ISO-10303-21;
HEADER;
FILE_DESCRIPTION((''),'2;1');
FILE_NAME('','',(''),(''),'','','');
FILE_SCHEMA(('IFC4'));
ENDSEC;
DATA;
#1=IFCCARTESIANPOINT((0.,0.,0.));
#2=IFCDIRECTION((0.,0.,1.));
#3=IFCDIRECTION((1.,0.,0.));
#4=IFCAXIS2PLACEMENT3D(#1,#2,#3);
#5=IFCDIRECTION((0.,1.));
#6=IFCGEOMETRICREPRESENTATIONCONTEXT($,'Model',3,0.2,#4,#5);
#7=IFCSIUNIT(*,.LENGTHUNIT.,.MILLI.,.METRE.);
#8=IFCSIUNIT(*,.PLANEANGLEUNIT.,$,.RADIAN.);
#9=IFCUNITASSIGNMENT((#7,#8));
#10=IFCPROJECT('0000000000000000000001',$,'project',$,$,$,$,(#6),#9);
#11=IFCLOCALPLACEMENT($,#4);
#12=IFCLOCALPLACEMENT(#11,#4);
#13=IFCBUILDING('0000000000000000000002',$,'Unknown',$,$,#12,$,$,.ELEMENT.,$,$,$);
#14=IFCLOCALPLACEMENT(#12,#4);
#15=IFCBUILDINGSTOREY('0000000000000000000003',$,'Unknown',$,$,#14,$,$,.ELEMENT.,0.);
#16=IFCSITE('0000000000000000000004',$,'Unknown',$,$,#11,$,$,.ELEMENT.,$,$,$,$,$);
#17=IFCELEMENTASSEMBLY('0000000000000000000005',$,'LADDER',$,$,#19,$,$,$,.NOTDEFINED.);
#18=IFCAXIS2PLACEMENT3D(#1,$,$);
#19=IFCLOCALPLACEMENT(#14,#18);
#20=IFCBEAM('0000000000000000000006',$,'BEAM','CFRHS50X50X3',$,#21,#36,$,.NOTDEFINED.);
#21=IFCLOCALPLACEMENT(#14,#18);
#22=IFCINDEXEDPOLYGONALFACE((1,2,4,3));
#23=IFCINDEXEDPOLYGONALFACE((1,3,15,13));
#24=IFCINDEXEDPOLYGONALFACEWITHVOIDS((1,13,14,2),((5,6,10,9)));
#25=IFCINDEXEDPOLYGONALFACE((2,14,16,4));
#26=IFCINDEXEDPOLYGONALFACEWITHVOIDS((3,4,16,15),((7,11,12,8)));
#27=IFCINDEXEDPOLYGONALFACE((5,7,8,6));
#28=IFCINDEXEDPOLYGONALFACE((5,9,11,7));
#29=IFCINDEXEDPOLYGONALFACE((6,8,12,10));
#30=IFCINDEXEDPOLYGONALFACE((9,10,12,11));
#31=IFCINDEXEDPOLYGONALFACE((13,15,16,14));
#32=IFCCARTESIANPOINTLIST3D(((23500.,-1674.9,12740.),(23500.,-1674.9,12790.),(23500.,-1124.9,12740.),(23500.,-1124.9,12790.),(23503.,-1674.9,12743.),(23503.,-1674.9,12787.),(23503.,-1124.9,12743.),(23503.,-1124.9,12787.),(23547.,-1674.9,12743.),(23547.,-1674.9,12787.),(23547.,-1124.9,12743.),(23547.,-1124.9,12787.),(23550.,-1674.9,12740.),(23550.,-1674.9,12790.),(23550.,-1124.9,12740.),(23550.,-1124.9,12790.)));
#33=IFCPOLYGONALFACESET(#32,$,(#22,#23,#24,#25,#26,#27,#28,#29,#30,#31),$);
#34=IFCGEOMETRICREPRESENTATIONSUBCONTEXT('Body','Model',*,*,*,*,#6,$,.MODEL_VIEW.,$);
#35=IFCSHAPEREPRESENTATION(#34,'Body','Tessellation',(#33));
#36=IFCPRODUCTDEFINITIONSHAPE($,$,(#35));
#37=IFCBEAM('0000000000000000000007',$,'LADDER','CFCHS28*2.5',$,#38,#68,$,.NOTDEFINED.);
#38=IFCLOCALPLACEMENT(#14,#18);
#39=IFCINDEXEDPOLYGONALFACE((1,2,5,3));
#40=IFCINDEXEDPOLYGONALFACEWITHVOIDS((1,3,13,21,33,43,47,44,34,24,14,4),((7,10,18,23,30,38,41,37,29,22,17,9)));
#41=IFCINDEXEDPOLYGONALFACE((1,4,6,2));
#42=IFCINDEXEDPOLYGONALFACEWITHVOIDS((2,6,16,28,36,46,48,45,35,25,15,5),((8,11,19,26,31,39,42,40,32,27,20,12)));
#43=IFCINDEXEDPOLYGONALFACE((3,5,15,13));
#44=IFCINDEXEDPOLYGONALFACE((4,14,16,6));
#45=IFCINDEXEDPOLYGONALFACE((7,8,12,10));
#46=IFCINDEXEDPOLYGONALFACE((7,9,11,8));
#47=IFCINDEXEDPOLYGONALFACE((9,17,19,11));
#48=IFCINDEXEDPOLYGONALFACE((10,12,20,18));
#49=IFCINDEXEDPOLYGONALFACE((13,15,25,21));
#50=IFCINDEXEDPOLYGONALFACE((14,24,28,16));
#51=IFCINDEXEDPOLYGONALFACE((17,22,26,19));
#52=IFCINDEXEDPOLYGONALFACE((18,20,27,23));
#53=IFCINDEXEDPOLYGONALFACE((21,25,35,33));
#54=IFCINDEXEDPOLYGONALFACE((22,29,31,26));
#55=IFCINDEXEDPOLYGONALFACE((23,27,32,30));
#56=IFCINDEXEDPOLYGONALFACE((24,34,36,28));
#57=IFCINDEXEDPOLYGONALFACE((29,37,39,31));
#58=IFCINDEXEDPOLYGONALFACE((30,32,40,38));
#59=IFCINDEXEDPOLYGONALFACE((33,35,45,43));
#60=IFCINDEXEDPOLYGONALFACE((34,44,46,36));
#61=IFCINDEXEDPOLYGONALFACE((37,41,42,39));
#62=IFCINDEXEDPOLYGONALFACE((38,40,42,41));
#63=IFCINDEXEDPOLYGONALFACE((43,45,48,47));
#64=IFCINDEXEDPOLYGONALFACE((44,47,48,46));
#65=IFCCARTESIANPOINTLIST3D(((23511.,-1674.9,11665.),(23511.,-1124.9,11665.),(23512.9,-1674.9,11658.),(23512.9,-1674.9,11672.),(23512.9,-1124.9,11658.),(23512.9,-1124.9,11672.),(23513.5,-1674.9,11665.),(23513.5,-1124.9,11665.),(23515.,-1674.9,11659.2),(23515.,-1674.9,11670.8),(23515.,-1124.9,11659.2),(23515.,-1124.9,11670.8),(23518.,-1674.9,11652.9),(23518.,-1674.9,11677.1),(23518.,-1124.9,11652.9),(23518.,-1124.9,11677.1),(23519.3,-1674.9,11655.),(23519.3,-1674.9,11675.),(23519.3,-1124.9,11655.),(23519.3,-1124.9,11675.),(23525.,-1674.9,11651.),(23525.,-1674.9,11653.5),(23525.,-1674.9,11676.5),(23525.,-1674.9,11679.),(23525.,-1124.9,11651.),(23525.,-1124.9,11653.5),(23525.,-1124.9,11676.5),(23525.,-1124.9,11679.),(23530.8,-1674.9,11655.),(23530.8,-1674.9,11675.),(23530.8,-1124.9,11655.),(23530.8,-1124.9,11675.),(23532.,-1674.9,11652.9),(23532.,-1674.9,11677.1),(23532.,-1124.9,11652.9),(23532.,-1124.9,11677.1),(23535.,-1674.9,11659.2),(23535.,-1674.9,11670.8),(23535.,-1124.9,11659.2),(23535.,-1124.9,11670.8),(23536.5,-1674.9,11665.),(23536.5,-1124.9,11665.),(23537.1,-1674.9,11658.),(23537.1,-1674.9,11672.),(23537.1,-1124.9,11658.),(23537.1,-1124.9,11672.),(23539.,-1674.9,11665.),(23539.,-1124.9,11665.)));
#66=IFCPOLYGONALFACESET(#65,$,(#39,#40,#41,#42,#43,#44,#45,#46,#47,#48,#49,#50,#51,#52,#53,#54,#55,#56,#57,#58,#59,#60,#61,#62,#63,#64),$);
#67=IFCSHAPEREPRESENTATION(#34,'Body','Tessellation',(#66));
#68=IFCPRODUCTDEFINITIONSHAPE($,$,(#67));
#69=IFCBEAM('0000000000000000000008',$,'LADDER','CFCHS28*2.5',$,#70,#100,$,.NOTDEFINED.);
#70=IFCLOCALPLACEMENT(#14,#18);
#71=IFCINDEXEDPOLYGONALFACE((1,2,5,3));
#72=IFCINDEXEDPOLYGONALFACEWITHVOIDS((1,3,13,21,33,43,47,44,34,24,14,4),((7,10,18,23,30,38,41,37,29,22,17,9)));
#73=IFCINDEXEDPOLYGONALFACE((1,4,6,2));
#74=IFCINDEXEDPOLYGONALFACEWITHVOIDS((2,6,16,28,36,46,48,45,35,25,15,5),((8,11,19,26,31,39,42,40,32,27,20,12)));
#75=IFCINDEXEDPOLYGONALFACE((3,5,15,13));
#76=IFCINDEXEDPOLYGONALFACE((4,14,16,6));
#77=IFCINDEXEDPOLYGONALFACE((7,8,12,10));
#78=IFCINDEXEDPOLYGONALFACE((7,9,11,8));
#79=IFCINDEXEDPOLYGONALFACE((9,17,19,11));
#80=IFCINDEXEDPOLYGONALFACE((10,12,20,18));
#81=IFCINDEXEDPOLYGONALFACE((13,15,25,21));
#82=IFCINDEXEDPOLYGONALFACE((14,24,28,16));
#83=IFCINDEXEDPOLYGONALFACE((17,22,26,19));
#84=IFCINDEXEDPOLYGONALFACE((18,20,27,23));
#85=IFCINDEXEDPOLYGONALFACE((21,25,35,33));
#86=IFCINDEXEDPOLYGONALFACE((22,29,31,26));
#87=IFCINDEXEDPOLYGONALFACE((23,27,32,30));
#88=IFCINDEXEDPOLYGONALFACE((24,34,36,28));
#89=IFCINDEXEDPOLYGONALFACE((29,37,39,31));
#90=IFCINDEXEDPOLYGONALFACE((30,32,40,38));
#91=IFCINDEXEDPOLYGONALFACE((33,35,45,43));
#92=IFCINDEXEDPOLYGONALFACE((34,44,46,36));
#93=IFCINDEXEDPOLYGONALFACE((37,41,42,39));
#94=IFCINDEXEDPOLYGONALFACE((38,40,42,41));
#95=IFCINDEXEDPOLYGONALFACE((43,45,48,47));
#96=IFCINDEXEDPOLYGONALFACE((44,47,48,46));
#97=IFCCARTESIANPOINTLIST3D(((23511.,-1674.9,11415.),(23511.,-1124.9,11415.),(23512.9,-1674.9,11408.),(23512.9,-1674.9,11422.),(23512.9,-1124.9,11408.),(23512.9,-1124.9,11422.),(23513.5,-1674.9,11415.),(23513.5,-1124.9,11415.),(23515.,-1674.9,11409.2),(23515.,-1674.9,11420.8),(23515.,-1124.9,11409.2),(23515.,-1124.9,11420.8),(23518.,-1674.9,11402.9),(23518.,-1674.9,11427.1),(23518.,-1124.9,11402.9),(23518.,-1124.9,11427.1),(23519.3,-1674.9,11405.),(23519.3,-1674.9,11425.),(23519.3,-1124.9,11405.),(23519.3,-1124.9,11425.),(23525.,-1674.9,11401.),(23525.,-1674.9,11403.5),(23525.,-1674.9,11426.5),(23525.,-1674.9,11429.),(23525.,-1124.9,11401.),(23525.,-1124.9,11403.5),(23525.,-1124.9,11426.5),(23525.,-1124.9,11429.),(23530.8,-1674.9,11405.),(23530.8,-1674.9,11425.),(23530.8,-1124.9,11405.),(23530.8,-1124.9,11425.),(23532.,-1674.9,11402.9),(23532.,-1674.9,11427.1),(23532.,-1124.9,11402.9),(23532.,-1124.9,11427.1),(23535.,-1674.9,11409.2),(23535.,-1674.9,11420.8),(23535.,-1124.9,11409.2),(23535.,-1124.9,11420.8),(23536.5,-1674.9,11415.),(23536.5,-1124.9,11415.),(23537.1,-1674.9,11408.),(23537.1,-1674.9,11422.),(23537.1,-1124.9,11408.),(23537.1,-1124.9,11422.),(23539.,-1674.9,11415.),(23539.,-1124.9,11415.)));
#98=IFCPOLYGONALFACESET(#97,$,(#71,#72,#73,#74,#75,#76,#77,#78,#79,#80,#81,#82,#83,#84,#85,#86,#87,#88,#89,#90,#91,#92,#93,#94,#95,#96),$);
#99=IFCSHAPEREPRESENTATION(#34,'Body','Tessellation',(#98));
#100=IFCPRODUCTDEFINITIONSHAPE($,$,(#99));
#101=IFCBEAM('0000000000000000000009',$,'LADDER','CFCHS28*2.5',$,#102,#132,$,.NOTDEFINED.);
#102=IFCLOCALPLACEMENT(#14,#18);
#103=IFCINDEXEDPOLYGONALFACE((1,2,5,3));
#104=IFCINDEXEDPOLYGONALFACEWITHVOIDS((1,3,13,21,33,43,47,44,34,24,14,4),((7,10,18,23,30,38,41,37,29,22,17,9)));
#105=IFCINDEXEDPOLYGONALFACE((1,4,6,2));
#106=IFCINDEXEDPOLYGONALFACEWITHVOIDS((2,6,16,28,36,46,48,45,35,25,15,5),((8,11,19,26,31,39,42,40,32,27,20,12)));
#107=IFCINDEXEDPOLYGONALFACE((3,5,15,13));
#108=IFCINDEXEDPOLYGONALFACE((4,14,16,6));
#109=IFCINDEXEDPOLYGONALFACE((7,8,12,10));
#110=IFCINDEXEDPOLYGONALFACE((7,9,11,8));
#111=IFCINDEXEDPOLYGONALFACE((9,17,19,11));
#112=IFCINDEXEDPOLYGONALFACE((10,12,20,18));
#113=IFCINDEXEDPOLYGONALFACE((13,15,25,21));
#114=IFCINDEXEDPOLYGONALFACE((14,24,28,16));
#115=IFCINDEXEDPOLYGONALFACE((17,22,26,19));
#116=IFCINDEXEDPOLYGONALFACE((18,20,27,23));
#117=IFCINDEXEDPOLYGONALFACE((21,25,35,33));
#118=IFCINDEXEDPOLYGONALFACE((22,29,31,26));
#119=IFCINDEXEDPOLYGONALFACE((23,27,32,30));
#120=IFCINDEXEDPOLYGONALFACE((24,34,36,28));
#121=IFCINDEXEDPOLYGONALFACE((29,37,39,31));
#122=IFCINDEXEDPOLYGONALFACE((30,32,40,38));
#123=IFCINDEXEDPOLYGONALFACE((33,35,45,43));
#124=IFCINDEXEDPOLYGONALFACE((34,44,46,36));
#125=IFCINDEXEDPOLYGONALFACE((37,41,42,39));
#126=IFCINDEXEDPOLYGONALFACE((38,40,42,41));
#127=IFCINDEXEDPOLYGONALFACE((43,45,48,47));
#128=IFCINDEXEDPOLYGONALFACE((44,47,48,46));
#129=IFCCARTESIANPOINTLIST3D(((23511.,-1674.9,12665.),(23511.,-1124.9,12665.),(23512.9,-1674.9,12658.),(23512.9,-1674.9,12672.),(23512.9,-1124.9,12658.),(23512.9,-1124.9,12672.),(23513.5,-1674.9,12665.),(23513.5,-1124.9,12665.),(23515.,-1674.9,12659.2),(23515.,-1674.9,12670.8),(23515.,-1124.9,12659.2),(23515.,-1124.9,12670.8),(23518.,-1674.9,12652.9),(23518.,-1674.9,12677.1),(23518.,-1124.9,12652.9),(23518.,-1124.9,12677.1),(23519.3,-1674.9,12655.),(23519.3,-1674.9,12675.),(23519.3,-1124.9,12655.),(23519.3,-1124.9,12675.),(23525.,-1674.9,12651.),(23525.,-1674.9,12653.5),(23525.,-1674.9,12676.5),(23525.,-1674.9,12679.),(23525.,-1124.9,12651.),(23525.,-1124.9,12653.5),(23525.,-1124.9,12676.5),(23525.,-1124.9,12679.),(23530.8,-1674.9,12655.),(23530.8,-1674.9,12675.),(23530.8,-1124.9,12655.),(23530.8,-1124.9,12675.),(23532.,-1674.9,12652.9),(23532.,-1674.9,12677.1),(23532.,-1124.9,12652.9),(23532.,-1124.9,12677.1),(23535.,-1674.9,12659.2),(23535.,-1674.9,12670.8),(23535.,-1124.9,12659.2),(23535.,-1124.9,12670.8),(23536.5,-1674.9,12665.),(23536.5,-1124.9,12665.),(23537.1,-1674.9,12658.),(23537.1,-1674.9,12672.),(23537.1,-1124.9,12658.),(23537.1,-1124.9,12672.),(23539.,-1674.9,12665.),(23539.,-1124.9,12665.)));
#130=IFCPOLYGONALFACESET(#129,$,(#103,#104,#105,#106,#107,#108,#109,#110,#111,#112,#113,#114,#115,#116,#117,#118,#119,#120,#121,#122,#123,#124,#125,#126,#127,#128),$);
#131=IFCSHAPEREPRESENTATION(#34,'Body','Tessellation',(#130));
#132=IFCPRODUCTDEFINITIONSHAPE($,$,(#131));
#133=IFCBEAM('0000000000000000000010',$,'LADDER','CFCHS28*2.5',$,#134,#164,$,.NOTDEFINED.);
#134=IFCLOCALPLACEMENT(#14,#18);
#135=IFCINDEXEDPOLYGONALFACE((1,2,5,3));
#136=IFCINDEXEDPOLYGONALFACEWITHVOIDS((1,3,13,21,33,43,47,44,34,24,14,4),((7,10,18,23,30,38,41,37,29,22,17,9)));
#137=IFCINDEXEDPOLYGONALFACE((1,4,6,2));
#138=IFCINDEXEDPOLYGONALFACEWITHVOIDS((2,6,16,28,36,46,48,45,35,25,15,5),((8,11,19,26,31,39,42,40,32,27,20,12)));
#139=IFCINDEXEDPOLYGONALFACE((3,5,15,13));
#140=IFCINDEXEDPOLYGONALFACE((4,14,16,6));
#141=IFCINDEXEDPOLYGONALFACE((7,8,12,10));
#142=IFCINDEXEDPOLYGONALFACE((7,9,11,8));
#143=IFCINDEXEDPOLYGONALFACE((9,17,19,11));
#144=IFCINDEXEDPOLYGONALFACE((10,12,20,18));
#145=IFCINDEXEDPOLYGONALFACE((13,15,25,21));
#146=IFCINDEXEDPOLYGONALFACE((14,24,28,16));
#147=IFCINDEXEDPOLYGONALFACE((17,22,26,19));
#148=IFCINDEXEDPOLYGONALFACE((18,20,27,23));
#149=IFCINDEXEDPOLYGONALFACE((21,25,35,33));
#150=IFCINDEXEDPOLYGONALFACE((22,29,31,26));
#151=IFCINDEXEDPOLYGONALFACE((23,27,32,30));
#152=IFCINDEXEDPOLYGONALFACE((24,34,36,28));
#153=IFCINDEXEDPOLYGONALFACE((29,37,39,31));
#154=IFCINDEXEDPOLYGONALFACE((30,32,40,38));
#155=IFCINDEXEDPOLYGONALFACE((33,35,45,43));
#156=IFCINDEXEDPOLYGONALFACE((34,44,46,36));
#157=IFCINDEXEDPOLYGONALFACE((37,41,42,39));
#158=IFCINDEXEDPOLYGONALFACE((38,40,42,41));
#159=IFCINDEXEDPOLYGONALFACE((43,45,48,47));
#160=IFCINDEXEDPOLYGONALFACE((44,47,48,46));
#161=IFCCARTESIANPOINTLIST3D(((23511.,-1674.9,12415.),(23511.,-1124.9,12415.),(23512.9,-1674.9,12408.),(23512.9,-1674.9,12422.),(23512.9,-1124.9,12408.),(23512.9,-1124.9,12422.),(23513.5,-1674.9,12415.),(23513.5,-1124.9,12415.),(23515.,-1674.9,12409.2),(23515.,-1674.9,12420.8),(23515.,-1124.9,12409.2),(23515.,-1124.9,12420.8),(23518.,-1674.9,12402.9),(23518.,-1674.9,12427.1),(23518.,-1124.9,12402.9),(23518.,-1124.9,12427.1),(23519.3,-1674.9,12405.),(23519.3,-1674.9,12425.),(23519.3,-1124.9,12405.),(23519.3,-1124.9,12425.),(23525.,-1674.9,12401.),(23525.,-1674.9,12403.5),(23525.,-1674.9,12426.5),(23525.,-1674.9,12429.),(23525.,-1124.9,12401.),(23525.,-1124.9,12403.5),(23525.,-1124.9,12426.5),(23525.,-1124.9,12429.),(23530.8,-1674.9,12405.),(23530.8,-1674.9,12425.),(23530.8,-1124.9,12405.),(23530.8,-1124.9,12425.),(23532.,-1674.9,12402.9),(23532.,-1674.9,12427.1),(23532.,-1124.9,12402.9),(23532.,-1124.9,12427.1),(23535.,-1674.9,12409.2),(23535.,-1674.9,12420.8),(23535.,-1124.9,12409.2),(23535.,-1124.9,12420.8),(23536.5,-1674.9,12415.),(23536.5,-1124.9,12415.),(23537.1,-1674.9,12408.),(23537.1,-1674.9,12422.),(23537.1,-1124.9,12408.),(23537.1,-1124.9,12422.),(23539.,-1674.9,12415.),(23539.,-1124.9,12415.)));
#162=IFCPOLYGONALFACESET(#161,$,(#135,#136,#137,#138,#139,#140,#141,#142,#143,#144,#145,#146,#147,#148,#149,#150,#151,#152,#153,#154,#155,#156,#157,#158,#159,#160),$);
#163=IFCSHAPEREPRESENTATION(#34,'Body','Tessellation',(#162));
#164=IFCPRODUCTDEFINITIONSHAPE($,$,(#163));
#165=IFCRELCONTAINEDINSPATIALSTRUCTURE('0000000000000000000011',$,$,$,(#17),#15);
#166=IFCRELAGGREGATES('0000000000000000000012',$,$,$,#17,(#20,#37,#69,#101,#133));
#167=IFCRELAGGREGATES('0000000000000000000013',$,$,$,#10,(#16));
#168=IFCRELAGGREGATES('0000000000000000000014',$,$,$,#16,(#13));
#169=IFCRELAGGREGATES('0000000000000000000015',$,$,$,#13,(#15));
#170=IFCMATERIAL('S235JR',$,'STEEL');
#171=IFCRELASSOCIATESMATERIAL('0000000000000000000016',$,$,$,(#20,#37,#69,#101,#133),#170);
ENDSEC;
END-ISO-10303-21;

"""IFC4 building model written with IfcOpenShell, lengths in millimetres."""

from ifc_helpers import new_model, si_unit, direction, frame, origin_with_axes, place, context, subcontext, project, spatial, line, indexed_curve, outline, extrude, material, element, aggregate, save


model = new_model("IFC4")

# Units and contexts
model_context = context("Model", 3, precision=0.2, world=origin_with_axes(), true_north=direction((0.0, 1.0)))
body_context = subcontext(model_context, "Body", "Model", "MODEL_VIEW")
ifc_project = project(units=[si_unit("LENGTHUNIT", "METRE", prefix="MILLI"), si_unit("PLANEANGLEUNIT", "RADIAN")], contexts=[model_context])

# Site, building, storey
site_placement = place(None, origin_with_axes())
site = spatial("IfcSite", under=ifc_project, at=site_placement, Name="Unknown", CompositionType="ELEMENT")
building_placement = place(site_placement, origin_with_axes())
building = spatial("IfcBuilding", under=site, at=building_placement, Name="Unknown", CompositionType="ELEMENT")
storey_placement = place(building_placement, origin_with_axes())
storey = spatial("IfcBuildingStorey", under=building, at=storey_placement, Name="Unknown", CompositionType="ELEMENT", Elevation=0.0)

# Element assembly, beams
assembly_1_placement = place(storey_placement, frame((23525.0, -1699.9, 5175.0), z_axis=(0.0, 1.0, 0.0), x_axis=(0.0, 0.0, 1.0)))
assembly_1 = element("IfcElementAssembly", 1, at=assembly_1_placement, inside=storey, Name="LADDER", PredefinedType="NOTDEFINED")
ifc_material_1 = material(Name="S235JR", Category="STEEL")
beam_1_placement = place(assembly_1_placement, frame((7590.0, 0.0, 25.0), z_axis=(0.0, 1.0, 0.0), x_axis=(0.0, 0.0, 1.0)))
beam_1 = element("IfcBeam", 2, at=beam_1_placement, material=ifc_material_1, Name="BEAM", Description="CFRHS50X50X3", PredefinedType="NOTDEFINED", context=body_context, shape_type="SolidModel", body=[
    extrude(outline(indexed_curve([(-25.0, -25.0), (25.0, -25.0), (25.0, 25.0), (-25.0, 25.0)], segments=[line(1, 2, 3, 4, 1)]), holes=[indexed_curve([(-22.0, -22.0), (-22.0, 22.0), (22.0, 22.0), (22.0, -22.0)], segments=[line(1, 2, 3, 4, 1)])]), frame((0.0, 0.0, 0.0), z_axis=(-1.0, 0.0, 0.0), x_axis=(0.0, 0.0, 1.0)), (0.0, 0.0, -1.0), 550.0),
])
beam_2_placement = place(assembly_1_placement, frame((6490.0, 0.0, 25.0), z_axis=(0.0, -1.0, 0.0), x_axis=(0.0, 0.0, 1.0)))
beam_2 = element("IfcBeam", 3, at=beam_2_placement, material=ifc_material_1, Name="LADDER", Description="CFCHS28*2.5", PredefinedType="NOTDEFINED", context=body_context, shape_type="SolidModel", body=[
    extrude(outline(indexed_curve([(14.0, 0.0), (12.1, 7.0), (7.0, 12.1), (0.0, 14.0), (-7.0, 12.1), (-12.1, 7.0), (-14.0, 0.0), (-12.1, -7.0), (-7.0, -12.1), (0.0, -14.0), (7.0, -12.1), (12.1, -7.0)], segments=[line(1, 2, 3, 4, 5, 6, 7, 8, 9, 10, 11, 12, 1)]), holes=[indexed_curve([(11.5, 0.0), (10.0, -5.8), (5.8, -10.0), (0.0, -11.5), (-5.8, -10.0), (-10.0, -5.8), (-11.5, 0.0), (-10.0, 5.8), (-5.8, 10.0), (0.0, 11.5), (5.8, 10.0), (10.0, 5.8)], segments=[line(1, 2, 3, 4, 5, 6, 7, 8, 9, 10, 11, 12, 1)])]), frame((0.0, 0.0, 0.0), z_axis=(-1.0, 0.0, 0.0), x_axis=(0.0, 0.0, 1.0)), (0.0, 0.0, -1.0), 550.0),
])
beam_3_placement = place(assembly_1_placement, frame((6240.0, 0.0, 25.0), z_axis=(0.0, -1.0, 0.0), x_axis=(0.0, 0.0, 1.0)))
beam_3 = element("IfcBeam", 4, at=beam_3_placement, material=ifc_material_1, Name="LADDER", Description="CFCHS28*2.5", PredefinedType="NOTDEFINED", context=body_context, shape_type="SolidModel", body=[
    extrude(outline(indexed_curve([(14.0, 0.0), (12.1, 7.0), (7.0, 12.1), (0.0, 14.0), (-7.0, 12.1), (-12.1, 7.0), (-14.0, 0.0), (-12.1, -7.0), (-7.0, -12.1), (0.0, -14.0), (7.0, -12.1), (12.1, -7.0)], segments=[line(1, 2, 3, 4, 5, 6, 7, 8, 9, 10, 11, 12, 1)]), holes=[indexed_curve([(11.5, 0.0), (10.0, -5.8), (5.8, -10.0), (0.0, -11.5), (-5.8, -10.0), (-10.0, -5.8), (-11.5, 0.0), (-10.0, 5.8), (-5.8, 10.0), (0.0, 11.5), (5.8, 10.0), (10.0, 5.8)], segments=[line(1, 2, 3, 4, 5, 6, 7, 8, 9, 10, 11, 12, 1)])]), frame((0.0, 0.0, 0.0), z_axis=(-1.0, 0.0, 0.0), x_axis=(0.0, 0.0, 1.0)), (0.0, 0.0, -1.0), 550.0),
])
beam_4_placement = place(assembly_1_placement, frame((7490.0, 0.0, 25.0), z_axis=(0.0, -1.0, 0.0), x_axis=(0.0, 0.0, 1.0)))
beam_4 = element("IfcBeam", 5, at=beam_4_placement, material=ifc_material_1, Name="LADDER", Description="CFCHS28*2.5", PredefinedType="NOTDEFINED", context=body_context, shape_type="SolidModel", body=[
    extrude(outline(indexed_curve([(14.0, 0.0), (12.1, 7.0), (7.0, 12.1), (0.0, 14.0), (-7.0, 12.1), (-12.1, 7.0), (-14.0, 0.0), (-12.1, -7.0), (-7.0, -12.1), (0.0, -14.0), (7.0, -12.1), (12.1, -7.0)], segments=[line(1, 2, 3, 4, 5, 6, 7, 8, 9, 10, 11, 12, 1)]), holes=[indexed_curve([(11.5, 0.0), (10.0, -5.8), (5.8, -10.0), (0.0, -11.5), (-5.8, -10.0), (-10.0, -5.8), (-11.5, 0.0), (-10.0, 5.8), (-5.8, 10.0), (0.0, 11.5), (5.8, 10.0), (10.0, 5.8)], segments=[line(1, 2, 3, 4, 5, 6, 7, 8, 9, 10, 11, 12, 1)])]), frame((0.0, 0.0, 0.0), z_axis=(-1.0, 0.0, 0.0), x_axis=(0.0, 0.0, 1.0)), (0.0, 0.0, -1.0), 550.0),
])
beam_5_placement = place(assembly_1_placement, frame((7240.0, 0.0, 25.0), z_axis=(0.0, -1.0, 0.0), x_axis=(0.0, 0.0, 1.0)))
beam_5 = element("IfcBeam", 6, at=beam_5_placement, material=ifc_material_1, Name="LADDER", Description="CFCHS28*2.5", PredefinedType="NOTDEFINED", context=body_context, shape_type="SolidModel", body=[
    extrude(outline(indexed_curve([(14.0, 0.0), (12.1, 7.0), (7.0, 12.1), (0.0, 14.0), (-7.0, 12.1), (-12.1, 7.0), (-14.0, 0.0), (-12.1, -7.0), (-7.0, -12.1), (0.0, -14.0), (7.0, -12.1), (12.1, -7.0)], segments=[line(1, 2, 3, 4, 5, 6, 7, 8, 9, 10, 11, 12, 1)]), holes=[indexed_curve([(11.5, 0.0), (10.0, -5.8), (5.8, -10.0), (0.0, -11.5), (-5.8, -10.0), (-10.0, -5.8), (-11.5, 0.0), (-10.0, 5.8), (-5.8, 10.0), (0.0, 11.5), (5.8, 10.0), (10.0, 5.8)], segments=[line(1, 2, 3, 4, 5, 6, 7, 8, 9, 10, 11, 12, 1)])]), frame((0.0, 0.0, 0.0), z_axis=(-1.0, 0.0, 0.0), x_axis=(0.0, 0.0, 1.0)), (0.0, 0.0, -1.0), 550.0),
])

aggregate(assembly_1, [beam_1, beam_2, beam_3, beam_4, beam_5])

save(model, "model.ifc")
